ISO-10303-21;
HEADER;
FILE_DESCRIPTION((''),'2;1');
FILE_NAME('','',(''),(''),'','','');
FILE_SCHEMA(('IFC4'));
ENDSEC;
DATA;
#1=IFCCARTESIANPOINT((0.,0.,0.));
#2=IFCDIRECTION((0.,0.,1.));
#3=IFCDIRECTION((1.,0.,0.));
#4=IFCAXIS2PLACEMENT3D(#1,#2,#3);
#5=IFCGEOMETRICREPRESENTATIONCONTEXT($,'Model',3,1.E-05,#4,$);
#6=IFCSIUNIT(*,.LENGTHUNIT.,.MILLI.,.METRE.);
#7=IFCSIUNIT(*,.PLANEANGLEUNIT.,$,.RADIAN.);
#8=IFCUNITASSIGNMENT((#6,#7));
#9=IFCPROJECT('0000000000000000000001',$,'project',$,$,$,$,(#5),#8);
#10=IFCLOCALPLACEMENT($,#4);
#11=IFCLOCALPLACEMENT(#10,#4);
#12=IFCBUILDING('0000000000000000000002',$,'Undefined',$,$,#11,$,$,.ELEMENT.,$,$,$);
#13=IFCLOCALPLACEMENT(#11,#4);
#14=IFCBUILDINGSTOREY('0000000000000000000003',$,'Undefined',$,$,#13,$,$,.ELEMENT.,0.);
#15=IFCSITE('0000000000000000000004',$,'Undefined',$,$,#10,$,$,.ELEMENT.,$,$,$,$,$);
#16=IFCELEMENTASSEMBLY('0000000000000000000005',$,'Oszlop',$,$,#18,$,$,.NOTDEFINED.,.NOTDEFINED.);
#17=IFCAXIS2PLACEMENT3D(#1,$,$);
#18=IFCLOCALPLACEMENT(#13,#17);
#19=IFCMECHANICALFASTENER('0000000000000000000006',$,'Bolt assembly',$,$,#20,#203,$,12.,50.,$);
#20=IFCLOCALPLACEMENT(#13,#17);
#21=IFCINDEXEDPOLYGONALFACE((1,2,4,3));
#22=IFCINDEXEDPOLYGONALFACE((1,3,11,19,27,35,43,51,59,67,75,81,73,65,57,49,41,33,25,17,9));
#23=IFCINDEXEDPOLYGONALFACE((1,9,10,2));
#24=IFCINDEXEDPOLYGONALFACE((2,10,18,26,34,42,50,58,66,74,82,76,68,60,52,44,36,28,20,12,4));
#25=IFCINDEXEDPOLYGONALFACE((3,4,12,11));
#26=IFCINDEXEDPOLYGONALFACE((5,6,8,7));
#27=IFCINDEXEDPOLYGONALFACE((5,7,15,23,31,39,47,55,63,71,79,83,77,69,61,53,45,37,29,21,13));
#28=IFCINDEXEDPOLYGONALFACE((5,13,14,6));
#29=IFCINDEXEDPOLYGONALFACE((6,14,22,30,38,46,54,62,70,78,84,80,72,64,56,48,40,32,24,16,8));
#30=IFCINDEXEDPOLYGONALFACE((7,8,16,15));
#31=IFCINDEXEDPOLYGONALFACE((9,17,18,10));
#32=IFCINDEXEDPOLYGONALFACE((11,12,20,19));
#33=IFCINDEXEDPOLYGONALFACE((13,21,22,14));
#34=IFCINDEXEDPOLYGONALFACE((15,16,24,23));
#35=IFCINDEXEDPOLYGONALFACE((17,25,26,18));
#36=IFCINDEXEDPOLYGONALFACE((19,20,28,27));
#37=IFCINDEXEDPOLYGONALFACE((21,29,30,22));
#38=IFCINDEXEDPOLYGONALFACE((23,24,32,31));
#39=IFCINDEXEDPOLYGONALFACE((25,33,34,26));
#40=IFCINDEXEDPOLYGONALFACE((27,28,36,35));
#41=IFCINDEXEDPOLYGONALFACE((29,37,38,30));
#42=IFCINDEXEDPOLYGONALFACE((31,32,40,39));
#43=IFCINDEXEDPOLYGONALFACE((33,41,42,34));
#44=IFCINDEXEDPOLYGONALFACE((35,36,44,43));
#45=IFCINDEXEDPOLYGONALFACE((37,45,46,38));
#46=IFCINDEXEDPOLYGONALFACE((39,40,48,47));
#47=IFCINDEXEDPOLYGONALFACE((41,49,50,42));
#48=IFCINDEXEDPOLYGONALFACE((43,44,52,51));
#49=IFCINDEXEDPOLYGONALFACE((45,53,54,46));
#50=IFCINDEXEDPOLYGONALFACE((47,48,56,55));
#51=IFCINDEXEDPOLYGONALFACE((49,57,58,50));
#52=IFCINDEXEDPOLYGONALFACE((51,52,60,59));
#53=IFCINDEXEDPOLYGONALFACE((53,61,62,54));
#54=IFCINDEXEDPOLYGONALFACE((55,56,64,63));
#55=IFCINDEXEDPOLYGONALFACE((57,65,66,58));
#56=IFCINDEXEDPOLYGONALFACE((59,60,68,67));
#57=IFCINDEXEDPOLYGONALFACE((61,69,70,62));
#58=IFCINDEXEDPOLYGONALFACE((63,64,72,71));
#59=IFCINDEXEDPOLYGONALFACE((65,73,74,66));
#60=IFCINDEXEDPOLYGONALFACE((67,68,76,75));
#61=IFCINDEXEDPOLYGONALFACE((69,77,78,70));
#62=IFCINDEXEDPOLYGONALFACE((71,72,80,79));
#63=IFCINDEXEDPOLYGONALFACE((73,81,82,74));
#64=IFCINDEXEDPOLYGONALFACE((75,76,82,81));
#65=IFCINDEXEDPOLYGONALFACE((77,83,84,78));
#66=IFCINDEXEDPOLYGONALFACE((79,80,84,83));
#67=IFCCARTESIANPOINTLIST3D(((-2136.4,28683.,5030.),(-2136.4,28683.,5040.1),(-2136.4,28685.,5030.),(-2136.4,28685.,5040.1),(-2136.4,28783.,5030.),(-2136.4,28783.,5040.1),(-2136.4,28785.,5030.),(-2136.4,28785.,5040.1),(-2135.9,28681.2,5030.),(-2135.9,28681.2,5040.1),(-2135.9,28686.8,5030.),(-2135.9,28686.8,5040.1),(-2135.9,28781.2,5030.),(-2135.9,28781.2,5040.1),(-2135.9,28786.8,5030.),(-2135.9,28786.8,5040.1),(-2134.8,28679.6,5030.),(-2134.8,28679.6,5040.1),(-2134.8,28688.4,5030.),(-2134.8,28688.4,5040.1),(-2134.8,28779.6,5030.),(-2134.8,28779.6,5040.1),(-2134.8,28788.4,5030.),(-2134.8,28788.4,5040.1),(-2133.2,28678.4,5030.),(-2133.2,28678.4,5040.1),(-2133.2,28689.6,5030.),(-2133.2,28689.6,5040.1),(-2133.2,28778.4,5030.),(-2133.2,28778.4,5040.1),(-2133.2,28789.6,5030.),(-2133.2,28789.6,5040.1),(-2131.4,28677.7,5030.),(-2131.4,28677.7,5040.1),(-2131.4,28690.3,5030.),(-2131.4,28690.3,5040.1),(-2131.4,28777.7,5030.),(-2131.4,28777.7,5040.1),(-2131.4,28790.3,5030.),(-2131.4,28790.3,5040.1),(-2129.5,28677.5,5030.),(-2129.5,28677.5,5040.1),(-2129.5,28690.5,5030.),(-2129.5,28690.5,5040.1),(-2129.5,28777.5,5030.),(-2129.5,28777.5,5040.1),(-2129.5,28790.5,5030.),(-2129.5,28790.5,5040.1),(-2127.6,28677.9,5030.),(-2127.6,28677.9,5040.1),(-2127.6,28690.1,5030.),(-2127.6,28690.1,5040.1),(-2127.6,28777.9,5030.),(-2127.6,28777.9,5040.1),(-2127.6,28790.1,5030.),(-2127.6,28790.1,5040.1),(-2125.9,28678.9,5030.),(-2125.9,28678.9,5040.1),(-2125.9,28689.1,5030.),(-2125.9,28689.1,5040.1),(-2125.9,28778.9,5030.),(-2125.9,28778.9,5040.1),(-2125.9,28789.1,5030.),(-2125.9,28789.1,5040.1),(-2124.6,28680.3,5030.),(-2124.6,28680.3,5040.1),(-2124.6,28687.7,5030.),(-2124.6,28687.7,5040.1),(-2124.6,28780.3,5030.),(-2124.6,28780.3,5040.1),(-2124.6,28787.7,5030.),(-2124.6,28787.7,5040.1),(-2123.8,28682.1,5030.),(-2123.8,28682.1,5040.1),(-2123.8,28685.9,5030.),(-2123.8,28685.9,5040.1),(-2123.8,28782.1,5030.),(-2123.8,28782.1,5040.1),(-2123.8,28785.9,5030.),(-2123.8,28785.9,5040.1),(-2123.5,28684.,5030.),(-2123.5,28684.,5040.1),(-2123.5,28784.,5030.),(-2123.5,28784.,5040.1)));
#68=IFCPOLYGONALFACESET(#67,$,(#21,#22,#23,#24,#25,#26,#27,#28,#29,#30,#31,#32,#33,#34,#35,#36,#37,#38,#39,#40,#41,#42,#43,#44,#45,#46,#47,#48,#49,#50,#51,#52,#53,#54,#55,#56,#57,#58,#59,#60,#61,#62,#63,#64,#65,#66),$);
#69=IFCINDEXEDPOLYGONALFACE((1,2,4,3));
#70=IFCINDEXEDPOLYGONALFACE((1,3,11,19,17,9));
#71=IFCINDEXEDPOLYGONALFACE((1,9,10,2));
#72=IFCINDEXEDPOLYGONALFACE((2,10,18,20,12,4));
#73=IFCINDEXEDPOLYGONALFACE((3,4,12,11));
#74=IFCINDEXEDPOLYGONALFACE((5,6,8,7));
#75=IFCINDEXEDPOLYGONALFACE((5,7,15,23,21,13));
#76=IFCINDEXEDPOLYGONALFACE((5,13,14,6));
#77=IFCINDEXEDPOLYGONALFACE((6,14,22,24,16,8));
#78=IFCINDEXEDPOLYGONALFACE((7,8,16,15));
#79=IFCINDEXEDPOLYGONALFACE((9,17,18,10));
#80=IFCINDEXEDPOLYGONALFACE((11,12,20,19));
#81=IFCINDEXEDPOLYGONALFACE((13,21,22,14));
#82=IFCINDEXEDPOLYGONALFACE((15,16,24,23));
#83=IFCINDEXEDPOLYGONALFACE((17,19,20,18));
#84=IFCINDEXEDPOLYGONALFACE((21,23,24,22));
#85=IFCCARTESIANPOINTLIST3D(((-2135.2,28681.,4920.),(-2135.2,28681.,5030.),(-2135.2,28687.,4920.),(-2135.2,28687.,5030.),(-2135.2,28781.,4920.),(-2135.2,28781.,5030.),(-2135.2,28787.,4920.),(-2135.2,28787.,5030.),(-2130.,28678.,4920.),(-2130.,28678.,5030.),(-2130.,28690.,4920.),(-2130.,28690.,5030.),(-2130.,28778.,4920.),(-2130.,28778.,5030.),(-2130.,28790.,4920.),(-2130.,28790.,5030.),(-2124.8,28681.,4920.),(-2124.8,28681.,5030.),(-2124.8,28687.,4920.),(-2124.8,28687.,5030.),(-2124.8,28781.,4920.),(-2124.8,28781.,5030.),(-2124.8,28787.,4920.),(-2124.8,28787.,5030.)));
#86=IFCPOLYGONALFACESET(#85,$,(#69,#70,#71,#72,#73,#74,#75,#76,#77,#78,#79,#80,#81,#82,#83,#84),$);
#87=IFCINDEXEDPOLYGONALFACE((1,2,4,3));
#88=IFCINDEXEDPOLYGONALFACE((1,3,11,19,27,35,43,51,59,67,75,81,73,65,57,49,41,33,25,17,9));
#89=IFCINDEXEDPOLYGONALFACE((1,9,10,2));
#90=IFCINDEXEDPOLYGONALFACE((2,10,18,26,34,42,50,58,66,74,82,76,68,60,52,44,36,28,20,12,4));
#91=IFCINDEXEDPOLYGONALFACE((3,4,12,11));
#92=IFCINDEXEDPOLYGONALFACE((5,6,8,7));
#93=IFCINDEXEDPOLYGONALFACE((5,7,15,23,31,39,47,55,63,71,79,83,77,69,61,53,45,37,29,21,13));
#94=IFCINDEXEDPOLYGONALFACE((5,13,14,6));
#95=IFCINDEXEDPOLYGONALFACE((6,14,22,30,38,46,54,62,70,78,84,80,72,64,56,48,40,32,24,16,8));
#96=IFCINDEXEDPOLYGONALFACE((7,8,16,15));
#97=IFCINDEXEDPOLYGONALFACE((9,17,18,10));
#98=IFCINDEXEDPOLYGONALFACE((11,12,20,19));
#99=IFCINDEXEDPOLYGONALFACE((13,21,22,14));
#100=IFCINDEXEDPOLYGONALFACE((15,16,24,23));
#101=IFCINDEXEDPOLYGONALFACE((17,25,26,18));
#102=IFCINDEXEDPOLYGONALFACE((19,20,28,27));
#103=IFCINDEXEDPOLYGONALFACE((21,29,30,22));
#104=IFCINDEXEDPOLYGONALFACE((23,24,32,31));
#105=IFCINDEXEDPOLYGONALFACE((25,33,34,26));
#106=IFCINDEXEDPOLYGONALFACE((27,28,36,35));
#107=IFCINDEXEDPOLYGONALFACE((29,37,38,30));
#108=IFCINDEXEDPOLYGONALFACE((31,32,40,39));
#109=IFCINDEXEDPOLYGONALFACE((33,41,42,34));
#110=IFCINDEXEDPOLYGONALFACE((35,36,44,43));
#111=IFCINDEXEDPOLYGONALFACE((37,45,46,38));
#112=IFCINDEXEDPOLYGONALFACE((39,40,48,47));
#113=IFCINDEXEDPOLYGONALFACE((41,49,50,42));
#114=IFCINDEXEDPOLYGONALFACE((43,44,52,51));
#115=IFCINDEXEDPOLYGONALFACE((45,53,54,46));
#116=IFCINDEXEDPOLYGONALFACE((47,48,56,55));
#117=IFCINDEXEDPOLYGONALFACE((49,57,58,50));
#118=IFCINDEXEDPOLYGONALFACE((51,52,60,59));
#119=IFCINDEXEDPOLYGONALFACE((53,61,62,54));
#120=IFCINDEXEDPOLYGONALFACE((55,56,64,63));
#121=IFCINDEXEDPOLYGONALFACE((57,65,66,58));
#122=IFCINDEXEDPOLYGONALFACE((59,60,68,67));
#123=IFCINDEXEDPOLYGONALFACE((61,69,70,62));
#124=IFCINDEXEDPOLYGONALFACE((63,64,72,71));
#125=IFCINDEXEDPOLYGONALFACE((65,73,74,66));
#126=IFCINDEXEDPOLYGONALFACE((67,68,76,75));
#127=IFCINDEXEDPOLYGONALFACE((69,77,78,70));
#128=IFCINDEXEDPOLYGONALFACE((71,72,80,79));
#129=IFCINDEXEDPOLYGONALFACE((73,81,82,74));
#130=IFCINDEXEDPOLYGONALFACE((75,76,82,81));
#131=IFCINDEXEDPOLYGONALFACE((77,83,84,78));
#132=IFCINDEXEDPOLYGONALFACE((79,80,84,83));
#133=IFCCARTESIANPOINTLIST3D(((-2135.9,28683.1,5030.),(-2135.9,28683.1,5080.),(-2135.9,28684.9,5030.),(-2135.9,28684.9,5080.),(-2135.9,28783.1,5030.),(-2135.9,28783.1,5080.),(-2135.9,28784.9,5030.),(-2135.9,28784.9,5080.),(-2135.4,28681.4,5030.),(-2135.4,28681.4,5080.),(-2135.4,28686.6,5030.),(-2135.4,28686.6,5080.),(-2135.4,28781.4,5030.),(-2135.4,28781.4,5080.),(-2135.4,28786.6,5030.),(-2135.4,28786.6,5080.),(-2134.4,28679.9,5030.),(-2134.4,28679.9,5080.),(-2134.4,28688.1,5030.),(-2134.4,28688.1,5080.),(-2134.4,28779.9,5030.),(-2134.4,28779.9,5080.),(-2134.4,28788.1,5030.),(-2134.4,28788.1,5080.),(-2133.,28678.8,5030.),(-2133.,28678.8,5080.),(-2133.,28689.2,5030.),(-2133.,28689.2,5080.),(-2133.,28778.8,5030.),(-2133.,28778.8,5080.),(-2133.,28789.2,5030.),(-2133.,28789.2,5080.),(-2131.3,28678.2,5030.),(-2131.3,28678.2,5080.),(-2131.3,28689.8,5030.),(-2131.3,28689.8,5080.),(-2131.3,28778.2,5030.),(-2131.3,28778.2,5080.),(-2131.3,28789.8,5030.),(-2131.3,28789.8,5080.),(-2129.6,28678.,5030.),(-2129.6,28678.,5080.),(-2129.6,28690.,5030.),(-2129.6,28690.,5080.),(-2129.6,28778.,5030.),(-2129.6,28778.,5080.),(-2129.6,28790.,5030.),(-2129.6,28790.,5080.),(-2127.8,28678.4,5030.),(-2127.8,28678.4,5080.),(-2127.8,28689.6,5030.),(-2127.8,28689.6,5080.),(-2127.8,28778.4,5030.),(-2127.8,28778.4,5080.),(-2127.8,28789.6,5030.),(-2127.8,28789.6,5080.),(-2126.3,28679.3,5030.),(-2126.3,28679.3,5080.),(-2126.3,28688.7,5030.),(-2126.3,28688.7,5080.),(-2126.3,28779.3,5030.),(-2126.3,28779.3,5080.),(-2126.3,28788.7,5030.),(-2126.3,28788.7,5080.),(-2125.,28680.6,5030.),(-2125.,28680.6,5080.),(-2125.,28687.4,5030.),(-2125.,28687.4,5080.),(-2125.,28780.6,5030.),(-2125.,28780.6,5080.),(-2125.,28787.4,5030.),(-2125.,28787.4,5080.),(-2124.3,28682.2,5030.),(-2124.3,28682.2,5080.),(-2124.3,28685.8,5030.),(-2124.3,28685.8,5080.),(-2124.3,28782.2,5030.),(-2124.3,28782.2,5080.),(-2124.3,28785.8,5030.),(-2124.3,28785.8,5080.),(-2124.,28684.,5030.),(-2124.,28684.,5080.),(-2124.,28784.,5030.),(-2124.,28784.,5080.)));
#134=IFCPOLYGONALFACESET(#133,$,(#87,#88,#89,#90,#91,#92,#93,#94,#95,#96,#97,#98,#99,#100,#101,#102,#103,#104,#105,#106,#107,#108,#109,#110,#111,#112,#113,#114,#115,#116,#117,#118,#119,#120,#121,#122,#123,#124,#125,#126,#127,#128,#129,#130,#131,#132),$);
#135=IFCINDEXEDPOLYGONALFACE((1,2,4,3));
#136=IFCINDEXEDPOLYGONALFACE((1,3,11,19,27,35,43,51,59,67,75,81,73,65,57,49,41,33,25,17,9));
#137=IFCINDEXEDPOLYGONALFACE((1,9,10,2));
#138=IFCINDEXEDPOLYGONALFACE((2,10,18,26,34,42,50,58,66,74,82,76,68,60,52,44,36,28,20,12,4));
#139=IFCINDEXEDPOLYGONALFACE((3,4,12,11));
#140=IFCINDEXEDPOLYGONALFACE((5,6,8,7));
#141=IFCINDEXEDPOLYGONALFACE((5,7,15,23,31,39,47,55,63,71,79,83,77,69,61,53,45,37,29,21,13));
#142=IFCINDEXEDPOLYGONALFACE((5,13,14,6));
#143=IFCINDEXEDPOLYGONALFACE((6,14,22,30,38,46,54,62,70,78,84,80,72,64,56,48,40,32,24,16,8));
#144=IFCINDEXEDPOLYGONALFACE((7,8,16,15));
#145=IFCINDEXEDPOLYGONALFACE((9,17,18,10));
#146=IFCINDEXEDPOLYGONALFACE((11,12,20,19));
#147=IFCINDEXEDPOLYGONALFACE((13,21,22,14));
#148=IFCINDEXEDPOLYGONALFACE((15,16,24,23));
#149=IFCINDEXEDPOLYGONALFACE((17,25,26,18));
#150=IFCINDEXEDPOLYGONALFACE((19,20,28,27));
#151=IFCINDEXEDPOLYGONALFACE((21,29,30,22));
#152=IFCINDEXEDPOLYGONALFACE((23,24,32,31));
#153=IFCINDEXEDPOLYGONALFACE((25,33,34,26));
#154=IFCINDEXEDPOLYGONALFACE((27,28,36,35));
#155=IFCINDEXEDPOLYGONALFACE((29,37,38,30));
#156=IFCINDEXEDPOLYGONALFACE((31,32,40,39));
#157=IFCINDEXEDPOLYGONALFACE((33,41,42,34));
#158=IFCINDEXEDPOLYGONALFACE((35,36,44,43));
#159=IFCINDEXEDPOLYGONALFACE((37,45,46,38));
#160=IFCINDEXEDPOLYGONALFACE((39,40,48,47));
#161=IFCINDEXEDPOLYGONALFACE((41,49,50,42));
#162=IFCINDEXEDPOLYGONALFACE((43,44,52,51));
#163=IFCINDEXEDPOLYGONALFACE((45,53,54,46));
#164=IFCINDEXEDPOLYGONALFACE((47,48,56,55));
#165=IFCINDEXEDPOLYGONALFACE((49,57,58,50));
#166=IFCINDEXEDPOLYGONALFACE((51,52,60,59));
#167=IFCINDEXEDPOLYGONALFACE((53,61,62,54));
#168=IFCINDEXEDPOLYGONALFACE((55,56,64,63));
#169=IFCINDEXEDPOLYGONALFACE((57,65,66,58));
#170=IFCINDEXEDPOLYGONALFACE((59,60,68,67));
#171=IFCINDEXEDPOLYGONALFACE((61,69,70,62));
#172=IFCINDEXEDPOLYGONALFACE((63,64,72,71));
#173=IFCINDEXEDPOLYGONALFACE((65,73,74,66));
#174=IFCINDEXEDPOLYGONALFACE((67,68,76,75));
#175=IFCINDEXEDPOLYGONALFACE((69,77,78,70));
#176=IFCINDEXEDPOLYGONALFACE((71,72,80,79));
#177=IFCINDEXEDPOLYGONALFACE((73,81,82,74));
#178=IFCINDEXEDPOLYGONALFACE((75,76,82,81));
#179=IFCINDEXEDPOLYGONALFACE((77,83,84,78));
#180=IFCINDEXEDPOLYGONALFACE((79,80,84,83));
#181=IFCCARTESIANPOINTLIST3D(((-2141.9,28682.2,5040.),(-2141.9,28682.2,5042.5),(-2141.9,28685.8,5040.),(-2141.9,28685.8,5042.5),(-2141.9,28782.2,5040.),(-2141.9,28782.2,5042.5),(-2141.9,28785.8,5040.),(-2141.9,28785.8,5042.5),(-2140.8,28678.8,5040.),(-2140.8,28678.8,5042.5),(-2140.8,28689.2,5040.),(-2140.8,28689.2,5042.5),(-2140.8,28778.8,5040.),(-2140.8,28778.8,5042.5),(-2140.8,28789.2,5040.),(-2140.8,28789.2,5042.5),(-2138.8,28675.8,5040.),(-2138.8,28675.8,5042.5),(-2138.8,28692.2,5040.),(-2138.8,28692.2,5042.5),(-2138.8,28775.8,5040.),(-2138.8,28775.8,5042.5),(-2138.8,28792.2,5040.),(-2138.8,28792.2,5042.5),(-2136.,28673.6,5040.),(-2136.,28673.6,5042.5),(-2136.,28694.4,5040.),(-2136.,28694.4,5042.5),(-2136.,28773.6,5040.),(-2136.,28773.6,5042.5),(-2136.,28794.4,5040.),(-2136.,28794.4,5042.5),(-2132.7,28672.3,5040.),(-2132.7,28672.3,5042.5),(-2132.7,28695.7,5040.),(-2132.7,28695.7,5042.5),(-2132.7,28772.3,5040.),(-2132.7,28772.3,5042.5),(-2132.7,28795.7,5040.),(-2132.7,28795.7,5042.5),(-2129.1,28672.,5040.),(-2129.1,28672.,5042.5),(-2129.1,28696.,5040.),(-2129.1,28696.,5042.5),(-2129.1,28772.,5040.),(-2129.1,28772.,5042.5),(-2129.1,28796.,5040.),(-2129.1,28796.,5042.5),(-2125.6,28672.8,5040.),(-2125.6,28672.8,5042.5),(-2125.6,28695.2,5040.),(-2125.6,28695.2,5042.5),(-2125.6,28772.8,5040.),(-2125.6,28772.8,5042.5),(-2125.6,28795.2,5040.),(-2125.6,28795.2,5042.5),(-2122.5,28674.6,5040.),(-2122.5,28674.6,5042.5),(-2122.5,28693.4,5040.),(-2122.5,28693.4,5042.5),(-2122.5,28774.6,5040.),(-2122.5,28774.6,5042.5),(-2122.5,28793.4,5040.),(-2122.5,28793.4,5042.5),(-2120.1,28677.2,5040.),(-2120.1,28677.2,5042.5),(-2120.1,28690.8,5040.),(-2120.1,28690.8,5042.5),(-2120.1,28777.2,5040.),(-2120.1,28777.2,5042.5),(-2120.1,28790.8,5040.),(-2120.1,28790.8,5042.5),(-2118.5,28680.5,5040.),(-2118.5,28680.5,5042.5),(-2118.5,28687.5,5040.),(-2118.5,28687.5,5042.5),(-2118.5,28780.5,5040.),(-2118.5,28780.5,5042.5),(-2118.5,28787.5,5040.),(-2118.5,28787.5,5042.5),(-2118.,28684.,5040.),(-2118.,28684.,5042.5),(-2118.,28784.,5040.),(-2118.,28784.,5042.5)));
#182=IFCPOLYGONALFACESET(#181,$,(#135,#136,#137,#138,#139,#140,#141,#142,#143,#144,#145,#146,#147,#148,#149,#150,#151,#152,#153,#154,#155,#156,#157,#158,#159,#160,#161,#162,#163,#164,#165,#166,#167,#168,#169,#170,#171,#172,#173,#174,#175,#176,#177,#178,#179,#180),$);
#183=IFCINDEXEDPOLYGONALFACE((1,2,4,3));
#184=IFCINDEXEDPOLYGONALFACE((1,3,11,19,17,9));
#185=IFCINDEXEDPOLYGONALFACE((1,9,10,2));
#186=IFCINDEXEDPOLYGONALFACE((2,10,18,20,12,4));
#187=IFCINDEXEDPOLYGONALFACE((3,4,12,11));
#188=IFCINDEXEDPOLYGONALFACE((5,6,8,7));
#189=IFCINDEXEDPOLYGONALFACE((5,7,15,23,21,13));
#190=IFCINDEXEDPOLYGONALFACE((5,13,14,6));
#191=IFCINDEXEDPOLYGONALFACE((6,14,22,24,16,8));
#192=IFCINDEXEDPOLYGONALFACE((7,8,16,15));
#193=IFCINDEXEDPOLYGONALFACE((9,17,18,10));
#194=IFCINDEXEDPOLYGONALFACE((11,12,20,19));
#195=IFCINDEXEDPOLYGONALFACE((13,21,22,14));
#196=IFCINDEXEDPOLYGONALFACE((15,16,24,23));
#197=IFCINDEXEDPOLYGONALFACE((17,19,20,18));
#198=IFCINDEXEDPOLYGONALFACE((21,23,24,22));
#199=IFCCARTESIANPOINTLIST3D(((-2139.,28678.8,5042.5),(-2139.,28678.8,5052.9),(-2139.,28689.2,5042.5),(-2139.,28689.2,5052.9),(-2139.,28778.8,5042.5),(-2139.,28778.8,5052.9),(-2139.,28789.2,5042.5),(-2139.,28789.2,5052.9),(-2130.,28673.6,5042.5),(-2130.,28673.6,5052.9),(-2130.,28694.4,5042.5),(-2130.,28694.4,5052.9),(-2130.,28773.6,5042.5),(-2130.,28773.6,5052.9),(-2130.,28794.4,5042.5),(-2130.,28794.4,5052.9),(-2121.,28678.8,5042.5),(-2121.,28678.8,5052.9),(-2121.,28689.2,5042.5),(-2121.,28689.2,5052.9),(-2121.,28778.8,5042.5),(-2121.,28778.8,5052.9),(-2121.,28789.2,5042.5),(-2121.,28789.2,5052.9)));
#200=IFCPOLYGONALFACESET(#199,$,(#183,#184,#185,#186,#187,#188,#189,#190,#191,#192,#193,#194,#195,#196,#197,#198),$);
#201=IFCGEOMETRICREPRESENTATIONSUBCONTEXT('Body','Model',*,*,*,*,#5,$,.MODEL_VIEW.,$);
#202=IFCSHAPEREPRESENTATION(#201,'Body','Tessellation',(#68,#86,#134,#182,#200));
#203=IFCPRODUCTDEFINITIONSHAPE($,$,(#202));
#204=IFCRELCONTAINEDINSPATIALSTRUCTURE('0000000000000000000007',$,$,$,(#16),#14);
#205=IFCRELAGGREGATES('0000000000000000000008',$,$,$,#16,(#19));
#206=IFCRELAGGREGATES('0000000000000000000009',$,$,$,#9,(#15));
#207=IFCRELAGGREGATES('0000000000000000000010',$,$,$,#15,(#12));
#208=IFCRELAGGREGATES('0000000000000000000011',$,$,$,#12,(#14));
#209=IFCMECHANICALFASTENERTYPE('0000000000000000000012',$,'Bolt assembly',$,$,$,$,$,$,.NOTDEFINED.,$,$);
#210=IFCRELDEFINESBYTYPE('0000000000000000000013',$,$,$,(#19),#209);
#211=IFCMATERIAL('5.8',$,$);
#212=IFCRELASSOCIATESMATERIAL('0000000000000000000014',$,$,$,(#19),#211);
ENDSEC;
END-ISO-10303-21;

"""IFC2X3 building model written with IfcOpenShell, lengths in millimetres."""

from ifc_helpers import new_model, si_unit, frame, origin_with_axes, origin_2d_with_axis, place, context, subcontext, project, spatial, polyline, circle, outline, extrude, source, transform, mapped, material, type_object, element, aggregate, save


model = new_model("IFC2X3")

# Units and contexts
model_context = context("Model", 3, precision=1e-05, world=origin_with_axes())
body_context = subcontext(model_context, "Body", "Model", "MODEL_VIEW")
ifc_project = project(units=[si_unit("LENGTHUNIT", "METRE", prefix="MILLI"), si_unit("PLANEANGLEUNIT", "RADIAN")], contexts=[model_context])

# Site, building, storey
site_placement = place(None, origin_with_axes())
site = spatial("IfcSite", under=ifc_project, at=site_placement, Name="Undefined", CompositionType="ELEMENT")
building_placement = place(site_placement, origin_with_axes())
building = spatial("IfcBuilding", under=site, at=building_placement, Name="Undefined", CompositionType="ELEMENT")
storey_placement = place(building_placement, origin_with_axes())
storey = spatial("IfcBuildingStorey", under=building, at=storey_placement, Name="Undefined", CompositionType="ELEMENT", Elevation=0.0)

# Element assembly
assembly_1_placement = place(storey_placement, origin_with_axes())
assembly_1 = element("IfcElementAssembly", 1, at=assembly_1_placement, inside=storey, Name="Oszlop", AssemblyPlace="NOTDEFINED", PredefinedType="NOTDEFINED")

# Mechanical fastener
ifc_material_1 = material(Name="5.8")
mechanical_fastener_type = type_object("IfcMechanicalFastenerType", Name="Bolt assembly")
shared_shape_1 = source(origin_with_axes(), body_context, "Body", "SweptSolid", [
    extrude(circle(Radius=6.5, at=origin_2d_with_axis()), frame((0.0, -10.0, 0.0), z_axis=(0.0, 1.0, 0.0), x_axis=(1.0, 0.0, 0.0)), (0.0, 0.0, 1.0), 10.1),
    extrude(outline(polyline([(5.2, -3.0), (5.2, 3.0), (0.0, 6.0), (-5.2, 3.0), (-5.2, -3.0), (0.0, -6.0), (5.2, -3.0)])), frame((0.0, -120.0, 0.0), z_axis=(0.0, 1.0, 0.0), x_axis=(1.0, 0.0, 0.0)), (0.0, 0.0, 1.0), 110.0),
    extrude(circle(Radius=6.0, at=origin_2d_with_axis()), frame((0.0, -10.0, 0.0), z_axis=(0.0, 1.0, 0.0), x_axis=(1.0, 0.0, 0.0)), (0.0, 0.0, 1.0), 50.0),
    extrude(circle(Radius=12.0, at=origin_2d_with_axis()), frame((0.0, 0.0, 0.0), z_axis=(0.0, 1.0, 0.0), x_axis=(1.0, 0.0, 0.0)), (0.0, 0.0, 1.0), 2.5),
    extrude(outline(polyline([(9.0, -5.2), (9.0, 5.2), (0.0, 10.4), (-9.0, 5.2), (-9.0, -5.2), (0.0, -10.4), (9.0, -5.2)])), frame((0.0, 2.5, 0.0), z_axis=(0.0, 1.0, 0.0), x_axis=(1.0, 0.0, 0.0)), (0.0, 0.0, 1.0), 10.4),
])
mechanical_fastener_1_placement = place(assembly_1_placement, frame((-2178.0, 28734.0, 5040.0), z_axis=(0.0, -1.0, 0.0), x_axis=(1.0, 0.0, 0.0)))
mechanical_fastener_1 = element("IfcMechanicalFastener", 2, at=mechanical_fastener_1_placement, type_object=mechanical_fastener_type, material=ifc_material_1, Name="Bolt assembly", NominalDiameter=12.0, NominalLength=50.0, context=body_context, shape_type="MappedRepresentation", body=[
    mapped(shared_shape_1, transform((48.0, 0.0, -50.0))),
    mapped(shared_shape_1, transform((48.0, 0.0, 50.0))),
])
aggregate(assembly_1, [mechanical_fastener_1])

save(model, "model.ifc")
